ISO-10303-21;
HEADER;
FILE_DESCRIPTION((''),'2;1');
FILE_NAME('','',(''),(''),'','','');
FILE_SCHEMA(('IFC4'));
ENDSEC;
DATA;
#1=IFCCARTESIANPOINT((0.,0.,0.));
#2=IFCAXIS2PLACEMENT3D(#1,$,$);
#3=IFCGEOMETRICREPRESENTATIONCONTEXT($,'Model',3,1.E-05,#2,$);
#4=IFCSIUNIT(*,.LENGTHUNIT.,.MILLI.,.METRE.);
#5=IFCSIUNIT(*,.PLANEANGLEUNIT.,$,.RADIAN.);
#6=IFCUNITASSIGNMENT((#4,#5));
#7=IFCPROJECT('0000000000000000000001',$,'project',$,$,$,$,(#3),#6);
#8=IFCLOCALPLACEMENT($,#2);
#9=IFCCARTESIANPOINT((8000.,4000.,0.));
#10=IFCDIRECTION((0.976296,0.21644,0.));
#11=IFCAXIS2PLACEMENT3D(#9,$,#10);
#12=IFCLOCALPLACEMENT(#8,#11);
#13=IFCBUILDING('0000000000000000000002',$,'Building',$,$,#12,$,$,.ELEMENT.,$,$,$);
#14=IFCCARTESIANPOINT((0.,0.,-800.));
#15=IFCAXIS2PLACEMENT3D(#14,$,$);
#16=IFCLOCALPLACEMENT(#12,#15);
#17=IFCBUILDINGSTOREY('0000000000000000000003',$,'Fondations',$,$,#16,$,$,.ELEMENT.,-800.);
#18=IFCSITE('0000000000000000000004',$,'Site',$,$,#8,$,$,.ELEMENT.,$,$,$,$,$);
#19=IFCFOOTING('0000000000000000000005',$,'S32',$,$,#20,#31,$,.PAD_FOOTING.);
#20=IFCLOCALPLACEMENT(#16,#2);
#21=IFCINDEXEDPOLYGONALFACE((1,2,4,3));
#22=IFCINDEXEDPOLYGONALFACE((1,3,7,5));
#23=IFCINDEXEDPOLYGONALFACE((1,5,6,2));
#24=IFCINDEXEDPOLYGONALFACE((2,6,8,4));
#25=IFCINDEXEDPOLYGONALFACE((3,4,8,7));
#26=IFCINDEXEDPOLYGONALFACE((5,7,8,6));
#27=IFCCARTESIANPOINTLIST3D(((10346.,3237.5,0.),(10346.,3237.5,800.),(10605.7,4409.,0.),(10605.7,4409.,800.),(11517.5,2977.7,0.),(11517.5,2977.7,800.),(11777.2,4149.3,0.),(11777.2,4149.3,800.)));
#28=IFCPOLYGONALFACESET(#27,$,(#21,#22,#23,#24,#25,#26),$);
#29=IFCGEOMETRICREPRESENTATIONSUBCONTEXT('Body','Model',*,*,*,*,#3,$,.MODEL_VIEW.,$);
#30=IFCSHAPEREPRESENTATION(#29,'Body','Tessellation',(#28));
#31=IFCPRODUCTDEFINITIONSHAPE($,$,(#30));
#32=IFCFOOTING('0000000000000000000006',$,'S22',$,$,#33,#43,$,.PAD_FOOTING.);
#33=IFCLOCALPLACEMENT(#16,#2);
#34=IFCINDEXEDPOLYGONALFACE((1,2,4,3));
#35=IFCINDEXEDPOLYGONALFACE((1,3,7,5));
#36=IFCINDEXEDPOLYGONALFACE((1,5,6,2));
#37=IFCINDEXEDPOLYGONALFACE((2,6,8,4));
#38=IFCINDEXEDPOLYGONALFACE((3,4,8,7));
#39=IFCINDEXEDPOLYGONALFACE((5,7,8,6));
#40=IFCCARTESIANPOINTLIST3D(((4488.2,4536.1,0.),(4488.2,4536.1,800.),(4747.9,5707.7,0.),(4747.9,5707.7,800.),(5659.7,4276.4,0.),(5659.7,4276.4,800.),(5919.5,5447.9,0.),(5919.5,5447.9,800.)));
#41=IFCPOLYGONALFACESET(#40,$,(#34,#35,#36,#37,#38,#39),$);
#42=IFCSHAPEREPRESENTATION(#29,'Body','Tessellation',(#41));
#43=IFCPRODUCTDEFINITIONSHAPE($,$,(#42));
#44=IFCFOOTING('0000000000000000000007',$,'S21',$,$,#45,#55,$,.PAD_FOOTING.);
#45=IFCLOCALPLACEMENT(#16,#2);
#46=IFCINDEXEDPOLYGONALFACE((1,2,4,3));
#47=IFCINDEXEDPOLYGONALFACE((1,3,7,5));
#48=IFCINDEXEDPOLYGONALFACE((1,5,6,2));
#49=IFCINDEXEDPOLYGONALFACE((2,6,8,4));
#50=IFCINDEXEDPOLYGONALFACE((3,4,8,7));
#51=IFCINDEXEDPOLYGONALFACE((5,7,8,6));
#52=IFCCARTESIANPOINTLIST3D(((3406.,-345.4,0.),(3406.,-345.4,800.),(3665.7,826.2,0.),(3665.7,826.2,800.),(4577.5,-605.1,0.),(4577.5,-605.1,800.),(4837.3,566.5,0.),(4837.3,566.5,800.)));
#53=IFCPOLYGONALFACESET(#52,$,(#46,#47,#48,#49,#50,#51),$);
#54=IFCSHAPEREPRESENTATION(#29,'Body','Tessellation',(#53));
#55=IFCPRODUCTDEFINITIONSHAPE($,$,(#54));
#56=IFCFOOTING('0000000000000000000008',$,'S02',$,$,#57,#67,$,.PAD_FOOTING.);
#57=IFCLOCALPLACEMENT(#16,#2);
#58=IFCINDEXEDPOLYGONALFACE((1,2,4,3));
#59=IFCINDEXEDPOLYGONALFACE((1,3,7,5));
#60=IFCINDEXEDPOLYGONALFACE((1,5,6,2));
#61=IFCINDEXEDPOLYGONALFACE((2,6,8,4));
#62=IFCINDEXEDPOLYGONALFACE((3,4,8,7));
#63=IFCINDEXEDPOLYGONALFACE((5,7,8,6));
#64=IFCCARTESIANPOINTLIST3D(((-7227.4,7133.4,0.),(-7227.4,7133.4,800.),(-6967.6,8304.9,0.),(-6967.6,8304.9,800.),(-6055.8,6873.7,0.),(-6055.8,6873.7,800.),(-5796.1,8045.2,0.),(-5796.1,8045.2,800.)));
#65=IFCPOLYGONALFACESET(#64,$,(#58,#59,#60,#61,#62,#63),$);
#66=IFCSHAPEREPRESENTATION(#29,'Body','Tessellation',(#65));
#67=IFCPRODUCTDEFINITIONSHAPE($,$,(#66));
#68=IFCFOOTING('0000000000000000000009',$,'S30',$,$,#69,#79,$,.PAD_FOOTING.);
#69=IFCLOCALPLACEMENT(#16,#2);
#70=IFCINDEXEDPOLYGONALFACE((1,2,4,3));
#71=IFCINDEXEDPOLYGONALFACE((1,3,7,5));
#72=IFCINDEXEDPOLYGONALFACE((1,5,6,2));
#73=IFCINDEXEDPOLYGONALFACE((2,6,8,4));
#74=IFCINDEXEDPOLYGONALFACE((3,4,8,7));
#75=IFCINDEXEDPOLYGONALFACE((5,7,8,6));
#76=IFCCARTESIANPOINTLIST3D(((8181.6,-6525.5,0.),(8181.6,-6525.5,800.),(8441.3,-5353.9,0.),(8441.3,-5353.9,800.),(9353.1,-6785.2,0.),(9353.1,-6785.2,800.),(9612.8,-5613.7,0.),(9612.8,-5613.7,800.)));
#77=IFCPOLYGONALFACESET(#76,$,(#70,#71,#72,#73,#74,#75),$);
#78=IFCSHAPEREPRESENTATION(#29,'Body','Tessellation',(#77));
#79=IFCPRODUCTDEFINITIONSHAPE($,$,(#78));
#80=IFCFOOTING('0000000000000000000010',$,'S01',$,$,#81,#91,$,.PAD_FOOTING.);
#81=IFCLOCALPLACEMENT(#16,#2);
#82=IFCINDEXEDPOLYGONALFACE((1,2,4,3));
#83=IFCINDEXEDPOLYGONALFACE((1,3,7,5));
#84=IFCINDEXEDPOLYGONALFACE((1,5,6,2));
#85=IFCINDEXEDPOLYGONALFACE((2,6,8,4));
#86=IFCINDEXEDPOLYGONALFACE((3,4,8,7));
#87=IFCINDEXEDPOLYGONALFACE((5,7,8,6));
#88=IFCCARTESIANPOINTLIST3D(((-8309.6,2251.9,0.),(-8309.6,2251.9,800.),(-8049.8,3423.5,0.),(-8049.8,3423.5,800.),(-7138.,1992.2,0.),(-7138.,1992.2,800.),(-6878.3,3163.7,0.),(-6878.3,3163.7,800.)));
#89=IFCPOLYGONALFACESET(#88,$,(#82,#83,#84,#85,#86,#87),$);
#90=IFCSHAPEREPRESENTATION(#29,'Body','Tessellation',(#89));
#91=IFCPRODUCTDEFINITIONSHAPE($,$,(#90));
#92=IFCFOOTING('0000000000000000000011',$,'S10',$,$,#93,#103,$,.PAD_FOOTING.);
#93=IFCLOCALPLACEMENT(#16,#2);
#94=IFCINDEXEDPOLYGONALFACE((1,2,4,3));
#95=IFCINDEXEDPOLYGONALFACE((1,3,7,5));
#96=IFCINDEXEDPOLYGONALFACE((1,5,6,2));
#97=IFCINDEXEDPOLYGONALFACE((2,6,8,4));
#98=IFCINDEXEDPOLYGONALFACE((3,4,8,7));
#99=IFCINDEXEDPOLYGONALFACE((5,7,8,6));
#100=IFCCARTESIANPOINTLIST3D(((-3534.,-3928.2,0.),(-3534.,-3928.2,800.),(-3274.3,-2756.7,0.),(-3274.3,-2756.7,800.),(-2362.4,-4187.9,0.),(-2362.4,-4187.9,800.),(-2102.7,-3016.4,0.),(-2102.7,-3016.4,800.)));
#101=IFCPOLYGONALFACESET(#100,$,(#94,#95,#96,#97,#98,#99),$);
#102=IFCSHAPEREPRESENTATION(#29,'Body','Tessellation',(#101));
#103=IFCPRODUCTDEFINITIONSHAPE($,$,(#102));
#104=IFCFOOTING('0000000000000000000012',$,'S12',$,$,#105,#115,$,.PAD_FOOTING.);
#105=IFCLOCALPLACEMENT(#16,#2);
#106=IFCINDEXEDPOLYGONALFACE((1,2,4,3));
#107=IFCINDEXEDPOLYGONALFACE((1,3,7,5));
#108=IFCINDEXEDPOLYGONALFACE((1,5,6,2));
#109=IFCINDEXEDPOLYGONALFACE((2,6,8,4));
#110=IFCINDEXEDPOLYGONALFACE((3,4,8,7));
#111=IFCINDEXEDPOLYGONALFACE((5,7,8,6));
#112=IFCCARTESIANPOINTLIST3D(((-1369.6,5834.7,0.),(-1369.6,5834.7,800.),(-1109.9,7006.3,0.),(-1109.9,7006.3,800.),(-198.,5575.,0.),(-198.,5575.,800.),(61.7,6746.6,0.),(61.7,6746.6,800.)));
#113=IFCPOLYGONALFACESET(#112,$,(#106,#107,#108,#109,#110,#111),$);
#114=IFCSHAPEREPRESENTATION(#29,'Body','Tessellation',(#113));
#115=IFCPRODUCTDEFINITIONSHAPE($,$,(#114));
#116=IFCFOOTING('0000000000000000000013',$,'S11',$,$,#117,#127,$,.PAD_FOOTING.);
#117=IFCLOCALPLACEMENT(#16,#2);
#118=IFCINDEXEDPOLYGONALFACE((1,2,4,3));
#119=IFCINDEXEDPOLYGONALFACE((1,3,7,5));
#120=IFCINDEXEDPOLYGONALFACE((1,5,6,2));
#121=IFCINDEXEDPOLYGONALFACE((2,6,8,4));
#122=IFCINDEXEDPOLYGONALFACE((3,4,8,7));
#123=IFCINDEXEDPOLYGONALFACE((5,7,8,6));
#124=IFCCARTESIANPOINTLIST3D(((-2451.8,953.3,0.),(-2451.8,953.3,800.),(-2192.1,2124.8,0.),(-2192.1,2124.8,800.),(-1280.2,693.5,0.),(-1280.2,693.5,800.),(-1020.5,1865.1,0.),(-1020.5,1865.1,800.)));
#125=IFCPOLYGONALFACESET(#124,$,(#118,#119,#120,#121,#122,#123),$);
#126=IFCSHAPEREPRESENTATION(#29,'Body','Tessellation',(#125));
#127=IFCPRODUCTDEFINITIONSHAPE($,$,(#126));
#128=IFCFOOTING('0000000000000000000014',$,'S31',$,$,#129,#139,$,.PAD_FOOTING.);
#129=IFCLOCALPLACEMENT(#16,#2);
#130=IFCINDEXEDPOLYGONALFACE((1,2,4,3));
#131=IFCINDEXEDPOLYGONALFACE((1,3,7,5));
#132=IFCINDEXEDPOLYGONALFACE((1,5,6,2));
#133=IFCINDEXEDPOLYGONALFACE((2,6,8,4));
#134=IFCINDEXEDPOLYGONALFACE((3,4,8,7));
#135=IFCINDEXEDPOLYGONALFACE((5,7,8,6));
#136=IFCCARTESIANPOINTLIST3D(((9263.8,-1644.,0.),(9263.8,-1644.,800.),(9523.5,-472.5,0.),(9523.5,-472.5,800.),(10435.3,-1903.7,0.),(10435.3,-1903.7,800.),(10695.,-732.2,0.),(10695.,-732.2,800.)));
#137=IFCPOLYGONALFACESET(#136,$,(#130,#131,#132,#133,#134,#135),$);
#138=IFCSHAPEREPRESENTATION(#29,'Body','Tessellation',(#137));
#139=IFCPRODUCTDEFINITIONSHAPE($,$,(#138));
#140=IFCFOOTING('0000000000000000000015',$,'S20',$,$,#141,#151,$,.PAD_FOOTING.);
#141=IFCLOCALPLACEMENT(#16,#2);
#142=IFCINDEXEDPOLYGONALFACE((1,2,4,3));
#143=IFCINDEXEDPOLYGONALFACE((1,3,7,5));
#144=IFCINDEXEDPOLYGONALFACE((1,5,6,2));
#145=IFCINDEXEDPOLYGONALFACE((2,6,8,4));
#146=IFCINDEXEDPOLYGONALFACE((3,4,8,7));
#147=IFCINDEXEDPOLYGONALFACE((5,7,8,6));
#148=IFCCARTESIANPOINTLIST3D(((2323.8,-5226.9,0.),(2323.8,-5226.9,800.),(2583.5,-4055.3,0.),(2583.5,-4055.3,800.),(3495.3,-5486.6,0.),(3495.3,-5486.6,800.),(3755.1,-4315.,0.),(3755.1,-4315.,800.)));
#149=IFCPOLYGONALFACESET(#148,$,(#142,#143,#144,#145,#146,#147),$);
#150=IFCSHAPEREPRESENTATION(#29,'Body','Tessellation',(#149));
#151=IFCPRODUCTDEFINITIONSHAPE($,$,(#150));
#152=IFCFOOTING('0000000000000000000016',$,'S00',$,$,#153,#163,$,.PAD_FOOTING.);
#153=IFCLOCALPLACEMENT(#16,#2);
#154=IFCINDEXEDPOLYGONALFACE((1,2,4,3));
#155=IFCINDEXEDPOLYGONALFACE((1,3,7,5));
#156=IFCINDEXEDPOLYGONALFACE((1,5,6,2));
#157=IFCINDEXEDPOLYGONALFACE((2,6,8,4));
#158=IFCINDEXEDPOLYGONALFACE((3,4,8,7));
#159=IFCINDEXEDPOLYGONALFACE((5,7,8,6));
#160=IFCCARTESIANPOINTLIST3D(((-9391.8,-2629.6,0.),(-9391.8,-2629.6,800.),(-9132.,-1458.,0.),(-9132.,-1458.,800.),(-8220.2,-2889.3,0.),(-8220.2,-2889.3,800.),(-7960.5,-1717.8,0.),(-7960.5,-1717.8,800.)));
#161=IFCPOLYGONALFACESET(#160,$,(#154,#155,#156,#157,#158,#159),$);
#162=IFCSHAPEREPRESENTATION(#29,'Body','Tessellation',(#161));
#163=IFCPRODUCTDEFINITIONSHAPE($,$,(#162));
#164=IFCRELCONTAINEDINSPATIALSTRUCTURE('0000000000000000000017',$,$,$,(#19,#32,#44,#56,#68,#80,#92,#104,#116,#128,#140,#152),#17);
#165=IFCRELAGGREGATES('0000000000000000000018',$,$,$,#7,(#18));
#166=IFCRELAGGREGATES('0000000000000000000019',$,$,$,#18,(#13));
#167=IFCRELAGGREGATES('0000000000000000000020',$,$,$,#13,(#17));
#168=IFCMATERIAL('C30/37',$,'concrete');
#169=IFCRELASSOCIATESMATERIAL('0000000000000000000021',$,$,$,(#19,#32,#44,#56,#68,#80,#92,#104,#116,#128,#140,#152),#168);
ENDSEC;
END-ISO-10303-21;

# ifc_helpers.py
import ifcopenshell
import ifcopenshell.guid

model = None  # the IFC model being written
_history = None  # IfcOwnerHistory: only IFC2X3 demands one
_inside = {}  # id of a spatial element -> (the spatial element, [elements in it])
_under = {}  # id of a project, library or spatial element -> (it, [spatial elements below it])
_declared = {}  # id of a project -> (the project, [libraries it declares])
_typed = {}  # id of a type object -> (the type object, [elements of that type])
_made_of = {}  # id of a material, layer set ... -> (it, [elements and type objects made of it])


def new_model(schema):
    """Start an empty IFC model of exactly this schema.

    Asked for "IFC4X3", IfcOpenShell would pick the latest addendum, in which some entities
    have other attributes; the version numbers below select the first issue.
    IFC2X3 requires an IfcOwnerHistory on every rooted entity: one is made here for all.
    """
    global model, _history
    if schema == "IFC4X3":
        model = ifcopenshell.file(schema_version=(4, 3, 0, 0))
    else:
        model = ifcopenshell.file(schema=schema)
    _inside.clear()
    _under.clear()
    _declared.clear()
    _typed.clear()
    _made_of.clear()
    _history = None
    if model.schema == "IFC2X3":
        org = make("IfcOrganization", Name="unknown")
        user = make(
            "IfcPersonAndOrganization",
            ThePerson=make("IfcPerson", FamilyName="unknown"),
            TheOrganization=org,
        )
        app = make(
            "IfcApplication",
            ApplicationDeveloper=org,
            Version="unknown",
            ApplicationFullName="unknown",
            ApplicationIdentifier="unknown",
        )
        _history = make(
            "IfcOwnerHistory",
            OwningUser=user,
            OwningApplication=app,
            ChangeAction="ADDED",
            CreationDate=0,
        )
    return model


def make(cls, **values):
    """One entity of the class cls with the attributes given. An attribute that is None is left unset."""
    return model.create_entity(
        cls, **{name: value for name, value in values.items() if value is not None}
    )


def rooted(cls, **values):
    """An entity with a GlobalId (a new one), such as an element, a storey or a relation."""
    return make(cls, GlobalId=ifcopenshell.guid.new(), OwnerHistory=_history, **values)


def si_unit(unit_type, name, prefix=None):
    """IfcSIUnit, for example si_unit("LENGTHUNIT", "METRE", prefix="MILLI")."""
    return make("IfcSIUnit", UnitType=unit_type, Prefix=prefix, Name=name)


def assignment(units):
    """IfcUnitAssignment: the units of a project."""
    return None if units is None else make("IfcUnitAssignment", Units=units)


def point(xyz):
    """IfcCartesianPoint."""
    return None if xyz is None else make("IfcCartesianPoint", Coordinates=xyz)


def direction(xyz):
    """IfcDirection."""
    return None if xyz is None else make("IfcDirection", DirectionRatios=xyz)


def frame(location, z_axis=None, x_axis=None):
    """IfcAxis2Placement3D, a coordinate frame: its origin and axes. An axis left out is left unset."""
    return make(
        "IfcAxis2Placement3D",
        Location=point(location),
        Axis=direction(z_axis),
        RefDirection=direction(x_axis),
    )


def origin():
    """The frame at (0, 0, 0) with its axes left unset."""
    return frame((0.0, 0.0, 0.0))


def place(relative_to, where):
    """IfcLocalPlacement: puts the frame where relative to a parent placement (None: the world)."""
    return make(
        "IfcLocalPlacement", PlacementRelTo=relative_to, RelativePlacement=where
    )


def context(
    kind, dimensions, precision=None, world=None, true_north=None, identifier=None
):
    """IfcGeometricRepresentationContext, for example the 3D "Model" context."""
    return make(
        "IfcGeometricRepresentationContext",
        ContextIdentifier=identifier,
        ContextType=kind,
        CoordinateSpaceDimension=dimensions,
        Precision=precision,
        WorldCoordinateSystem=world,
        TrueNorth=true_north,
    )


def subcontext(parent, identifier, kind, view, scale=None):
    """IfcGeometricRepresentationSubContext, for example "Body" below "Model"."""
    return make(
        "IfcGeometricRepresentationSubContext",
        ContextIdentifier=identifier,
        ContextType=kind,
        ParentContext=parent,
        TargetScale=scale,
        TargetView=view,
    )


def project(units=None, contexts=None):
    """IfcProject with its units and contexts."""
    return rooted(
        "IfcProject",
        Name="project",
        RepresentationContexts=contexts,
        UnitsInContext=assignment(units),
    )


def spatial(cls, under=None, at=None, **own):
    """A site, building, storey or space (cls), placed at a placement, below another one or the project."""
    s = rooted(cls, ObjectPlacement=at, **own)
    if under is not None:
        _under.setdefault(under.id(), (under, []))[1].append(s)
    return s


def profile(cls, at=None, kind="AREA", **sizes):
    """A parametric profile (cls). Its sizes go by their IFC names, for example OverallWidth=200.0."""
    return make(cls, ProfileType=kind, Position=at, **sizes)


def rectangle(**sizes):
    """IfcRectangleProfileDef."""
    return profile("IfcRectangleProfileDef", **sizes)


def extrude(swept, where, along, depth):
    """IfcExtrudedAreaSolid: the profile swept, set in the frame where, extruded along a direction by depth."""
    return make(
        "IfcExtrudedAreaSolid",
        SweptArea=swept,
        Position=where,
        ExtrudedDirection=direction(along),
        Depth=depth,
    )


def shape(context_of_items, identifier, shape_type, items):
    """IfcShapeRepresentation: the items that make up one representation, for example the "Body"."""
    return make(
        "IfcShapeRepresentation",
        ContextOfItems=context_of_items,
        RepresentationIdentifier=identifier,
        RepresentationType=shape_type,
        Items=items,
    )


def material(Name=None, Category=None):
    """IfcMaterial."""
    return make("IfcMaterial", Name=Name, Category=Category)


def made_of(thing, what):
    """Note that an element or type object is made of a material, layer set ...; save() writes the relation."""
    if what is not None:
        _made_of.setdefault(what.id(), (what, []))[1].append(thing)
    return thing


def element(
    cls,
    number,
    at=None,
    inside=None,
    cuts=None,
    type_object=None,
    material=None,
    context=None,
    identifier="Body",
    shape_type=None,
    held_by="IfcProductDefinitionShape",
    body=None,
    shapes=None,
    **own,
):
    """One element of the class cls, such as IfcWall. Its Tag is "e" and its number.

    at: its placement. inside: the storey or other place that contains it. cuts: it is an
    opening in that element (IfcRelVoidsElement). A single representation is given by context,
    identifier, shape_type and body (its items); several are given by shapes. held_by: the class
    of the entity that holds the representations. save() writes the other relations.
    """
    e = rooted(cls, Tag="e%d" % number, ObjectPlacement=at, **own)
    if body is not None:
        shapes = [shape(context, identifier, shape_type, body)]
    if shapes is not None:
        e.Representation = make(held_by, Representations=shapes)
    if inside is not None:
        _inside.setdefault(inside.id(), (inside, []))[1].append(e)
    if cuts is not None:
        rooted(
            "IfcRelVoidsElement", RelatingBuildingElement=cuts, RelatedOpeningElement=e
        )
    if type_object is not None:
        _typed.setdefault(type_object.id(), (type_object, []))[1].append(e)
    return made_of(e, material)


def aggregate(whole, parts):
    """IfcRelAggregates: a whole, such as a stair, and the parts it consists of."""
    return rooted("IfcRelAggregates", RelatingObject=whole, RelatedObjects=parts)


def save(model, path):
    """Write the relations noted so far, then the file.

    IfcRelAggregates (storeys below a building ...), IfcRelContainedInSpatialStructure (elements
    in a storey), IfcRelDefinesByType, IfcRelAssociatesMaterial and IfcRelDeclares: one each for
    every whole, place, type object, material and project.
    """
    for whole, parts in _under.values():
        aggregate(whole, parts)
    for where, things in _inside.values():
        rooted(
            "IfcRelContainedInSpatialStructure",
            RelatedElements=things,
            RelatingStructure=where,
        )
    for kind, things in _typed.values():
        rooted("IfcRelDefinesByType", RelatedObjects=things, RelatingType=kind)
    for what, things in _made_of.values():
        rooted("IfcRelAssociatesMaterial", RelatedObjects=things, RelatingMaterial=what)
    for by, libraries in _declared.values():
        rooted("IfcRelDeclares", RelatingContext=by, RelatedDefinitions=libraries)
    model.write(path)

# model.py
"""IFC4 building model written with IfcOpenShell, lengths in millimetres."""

from ifc_helpers import new_model, si_unit, frame, origin, place, context, subcontext, project, spatial, rectangle, extrude, material, element, save


model = new_model("IFC4")

# Units and contexts
model_context = context("Model", 3, precision=1e-05, world=origin())
body_context = subcontext(model_context, "Body", "Model", "MODEL_VIEW")
ifc_project = project(units=[si_unit("LENGTHUNIT", "METRE", prefix="MILLI"), si_unit("PLANEANGLEUNIT", "RADIAN")], contexts=[model_context])

# Site, building, storey
site_placement = place(None, origin())
site = spatial("IfcSite", under=ifc_project, at=site_placement, Name="Site", CompositionType="ELEMENT")
building_placement = place(site_placement, frame((8000.0, 4000.0, 0.0), x_axis=(0.976296, 0.21644, 0.0)))
building = spatial("IfcBuilding", under=site, at=building_placement, Name="Building", CompositionType="ELEMENT")
storey_placement = place(building_placement, frame((0.0, 0.0, -800.0)))
storey = spatial("IfcBuildingStorey", under=building, at=storey_placement, Name="Fondations", CompositionType="ELEMENT", Elevation=-800.0)

# Footings
ifc_material = material(Name="C30/37", Category="concrete")
for number, where, z_axis, x_axis, name in (
    (1, (11061.6, 3693.4, 0.0), (0.0, 0.0, 1.0), (0.976296, -0.21644, 0.0), "S32"),
    (2, (5203.8, 4992.0, 0.0), (0.0, 0.0, 1.0), (0.976296, -0.21644, 0.0), "S22"),
    (3, (4121.6, 110.5, 0.0), (0.0, 0.0, 1.0), (0.976296, -0.21644, 0.0), "S21"),
    (4, (-6511.7, 7589.3, 0.0), (0.0, 0.0, 1.0), (0.976296, -0.21644, 0.0), "S02"),
    (5, (8897.2, -6069.6, 0.0), (0.0, 0.0, 1.0), (0.976296, -0.21644, 0.0), "S30"),
    (6, (-7593.9, 2707.8, 0.0), (0.0, 0.0, 1.0), (0.976296, -0.21644, 0.0), "S01"),
    (7, (-2818.4, -3472.3, 0.0), (0.0, 0.0, 1.0), (0.976296, -0.21644, 0.0), "S10"),
    (8, (-654.0, 6290.7, 0.0), (0.0, 0.0, 1.0), (0.976296, -0.21644, 0.0), "S12"),
    (9, (-1736.2, 1409.2, 0.0), (0.0, 0.0, 1.0), (0.976296, -0.21644, 0.0), "S11"),
    (10, (9979.4, -1188.1, 0.0), (0.0, 0.0, 1.0), (0.976296, -0.21644, 0.0), "S31"),
    (11, (3039.4, -4770.9, 0.0), (0.0, 0.0, 1.0), (0.976296, -0.21644, 0.0), "S20"),
    (12, (-8676.1, -2173.7, 0.0), (0.0, 0.0, 1.0), (0.976296, -0.21644, 0.0), "S00"),
):
    element("IfcFooting", number, at=place(storey_placement, frame(where, z_axis=z_axis, x_axis=x_axis)), inside=storey, material=ifc_material, Name=name, PredefinedType="PAD_FOOTING", context=body_context, shape_type="SweptSolid", body=[
        extrude(rectangle(XDim=1200.0, YDim=1200.0), origin(), (0.0, 0.0, 1.0), 800.0),
    ])

save(model, "model.ifc")
